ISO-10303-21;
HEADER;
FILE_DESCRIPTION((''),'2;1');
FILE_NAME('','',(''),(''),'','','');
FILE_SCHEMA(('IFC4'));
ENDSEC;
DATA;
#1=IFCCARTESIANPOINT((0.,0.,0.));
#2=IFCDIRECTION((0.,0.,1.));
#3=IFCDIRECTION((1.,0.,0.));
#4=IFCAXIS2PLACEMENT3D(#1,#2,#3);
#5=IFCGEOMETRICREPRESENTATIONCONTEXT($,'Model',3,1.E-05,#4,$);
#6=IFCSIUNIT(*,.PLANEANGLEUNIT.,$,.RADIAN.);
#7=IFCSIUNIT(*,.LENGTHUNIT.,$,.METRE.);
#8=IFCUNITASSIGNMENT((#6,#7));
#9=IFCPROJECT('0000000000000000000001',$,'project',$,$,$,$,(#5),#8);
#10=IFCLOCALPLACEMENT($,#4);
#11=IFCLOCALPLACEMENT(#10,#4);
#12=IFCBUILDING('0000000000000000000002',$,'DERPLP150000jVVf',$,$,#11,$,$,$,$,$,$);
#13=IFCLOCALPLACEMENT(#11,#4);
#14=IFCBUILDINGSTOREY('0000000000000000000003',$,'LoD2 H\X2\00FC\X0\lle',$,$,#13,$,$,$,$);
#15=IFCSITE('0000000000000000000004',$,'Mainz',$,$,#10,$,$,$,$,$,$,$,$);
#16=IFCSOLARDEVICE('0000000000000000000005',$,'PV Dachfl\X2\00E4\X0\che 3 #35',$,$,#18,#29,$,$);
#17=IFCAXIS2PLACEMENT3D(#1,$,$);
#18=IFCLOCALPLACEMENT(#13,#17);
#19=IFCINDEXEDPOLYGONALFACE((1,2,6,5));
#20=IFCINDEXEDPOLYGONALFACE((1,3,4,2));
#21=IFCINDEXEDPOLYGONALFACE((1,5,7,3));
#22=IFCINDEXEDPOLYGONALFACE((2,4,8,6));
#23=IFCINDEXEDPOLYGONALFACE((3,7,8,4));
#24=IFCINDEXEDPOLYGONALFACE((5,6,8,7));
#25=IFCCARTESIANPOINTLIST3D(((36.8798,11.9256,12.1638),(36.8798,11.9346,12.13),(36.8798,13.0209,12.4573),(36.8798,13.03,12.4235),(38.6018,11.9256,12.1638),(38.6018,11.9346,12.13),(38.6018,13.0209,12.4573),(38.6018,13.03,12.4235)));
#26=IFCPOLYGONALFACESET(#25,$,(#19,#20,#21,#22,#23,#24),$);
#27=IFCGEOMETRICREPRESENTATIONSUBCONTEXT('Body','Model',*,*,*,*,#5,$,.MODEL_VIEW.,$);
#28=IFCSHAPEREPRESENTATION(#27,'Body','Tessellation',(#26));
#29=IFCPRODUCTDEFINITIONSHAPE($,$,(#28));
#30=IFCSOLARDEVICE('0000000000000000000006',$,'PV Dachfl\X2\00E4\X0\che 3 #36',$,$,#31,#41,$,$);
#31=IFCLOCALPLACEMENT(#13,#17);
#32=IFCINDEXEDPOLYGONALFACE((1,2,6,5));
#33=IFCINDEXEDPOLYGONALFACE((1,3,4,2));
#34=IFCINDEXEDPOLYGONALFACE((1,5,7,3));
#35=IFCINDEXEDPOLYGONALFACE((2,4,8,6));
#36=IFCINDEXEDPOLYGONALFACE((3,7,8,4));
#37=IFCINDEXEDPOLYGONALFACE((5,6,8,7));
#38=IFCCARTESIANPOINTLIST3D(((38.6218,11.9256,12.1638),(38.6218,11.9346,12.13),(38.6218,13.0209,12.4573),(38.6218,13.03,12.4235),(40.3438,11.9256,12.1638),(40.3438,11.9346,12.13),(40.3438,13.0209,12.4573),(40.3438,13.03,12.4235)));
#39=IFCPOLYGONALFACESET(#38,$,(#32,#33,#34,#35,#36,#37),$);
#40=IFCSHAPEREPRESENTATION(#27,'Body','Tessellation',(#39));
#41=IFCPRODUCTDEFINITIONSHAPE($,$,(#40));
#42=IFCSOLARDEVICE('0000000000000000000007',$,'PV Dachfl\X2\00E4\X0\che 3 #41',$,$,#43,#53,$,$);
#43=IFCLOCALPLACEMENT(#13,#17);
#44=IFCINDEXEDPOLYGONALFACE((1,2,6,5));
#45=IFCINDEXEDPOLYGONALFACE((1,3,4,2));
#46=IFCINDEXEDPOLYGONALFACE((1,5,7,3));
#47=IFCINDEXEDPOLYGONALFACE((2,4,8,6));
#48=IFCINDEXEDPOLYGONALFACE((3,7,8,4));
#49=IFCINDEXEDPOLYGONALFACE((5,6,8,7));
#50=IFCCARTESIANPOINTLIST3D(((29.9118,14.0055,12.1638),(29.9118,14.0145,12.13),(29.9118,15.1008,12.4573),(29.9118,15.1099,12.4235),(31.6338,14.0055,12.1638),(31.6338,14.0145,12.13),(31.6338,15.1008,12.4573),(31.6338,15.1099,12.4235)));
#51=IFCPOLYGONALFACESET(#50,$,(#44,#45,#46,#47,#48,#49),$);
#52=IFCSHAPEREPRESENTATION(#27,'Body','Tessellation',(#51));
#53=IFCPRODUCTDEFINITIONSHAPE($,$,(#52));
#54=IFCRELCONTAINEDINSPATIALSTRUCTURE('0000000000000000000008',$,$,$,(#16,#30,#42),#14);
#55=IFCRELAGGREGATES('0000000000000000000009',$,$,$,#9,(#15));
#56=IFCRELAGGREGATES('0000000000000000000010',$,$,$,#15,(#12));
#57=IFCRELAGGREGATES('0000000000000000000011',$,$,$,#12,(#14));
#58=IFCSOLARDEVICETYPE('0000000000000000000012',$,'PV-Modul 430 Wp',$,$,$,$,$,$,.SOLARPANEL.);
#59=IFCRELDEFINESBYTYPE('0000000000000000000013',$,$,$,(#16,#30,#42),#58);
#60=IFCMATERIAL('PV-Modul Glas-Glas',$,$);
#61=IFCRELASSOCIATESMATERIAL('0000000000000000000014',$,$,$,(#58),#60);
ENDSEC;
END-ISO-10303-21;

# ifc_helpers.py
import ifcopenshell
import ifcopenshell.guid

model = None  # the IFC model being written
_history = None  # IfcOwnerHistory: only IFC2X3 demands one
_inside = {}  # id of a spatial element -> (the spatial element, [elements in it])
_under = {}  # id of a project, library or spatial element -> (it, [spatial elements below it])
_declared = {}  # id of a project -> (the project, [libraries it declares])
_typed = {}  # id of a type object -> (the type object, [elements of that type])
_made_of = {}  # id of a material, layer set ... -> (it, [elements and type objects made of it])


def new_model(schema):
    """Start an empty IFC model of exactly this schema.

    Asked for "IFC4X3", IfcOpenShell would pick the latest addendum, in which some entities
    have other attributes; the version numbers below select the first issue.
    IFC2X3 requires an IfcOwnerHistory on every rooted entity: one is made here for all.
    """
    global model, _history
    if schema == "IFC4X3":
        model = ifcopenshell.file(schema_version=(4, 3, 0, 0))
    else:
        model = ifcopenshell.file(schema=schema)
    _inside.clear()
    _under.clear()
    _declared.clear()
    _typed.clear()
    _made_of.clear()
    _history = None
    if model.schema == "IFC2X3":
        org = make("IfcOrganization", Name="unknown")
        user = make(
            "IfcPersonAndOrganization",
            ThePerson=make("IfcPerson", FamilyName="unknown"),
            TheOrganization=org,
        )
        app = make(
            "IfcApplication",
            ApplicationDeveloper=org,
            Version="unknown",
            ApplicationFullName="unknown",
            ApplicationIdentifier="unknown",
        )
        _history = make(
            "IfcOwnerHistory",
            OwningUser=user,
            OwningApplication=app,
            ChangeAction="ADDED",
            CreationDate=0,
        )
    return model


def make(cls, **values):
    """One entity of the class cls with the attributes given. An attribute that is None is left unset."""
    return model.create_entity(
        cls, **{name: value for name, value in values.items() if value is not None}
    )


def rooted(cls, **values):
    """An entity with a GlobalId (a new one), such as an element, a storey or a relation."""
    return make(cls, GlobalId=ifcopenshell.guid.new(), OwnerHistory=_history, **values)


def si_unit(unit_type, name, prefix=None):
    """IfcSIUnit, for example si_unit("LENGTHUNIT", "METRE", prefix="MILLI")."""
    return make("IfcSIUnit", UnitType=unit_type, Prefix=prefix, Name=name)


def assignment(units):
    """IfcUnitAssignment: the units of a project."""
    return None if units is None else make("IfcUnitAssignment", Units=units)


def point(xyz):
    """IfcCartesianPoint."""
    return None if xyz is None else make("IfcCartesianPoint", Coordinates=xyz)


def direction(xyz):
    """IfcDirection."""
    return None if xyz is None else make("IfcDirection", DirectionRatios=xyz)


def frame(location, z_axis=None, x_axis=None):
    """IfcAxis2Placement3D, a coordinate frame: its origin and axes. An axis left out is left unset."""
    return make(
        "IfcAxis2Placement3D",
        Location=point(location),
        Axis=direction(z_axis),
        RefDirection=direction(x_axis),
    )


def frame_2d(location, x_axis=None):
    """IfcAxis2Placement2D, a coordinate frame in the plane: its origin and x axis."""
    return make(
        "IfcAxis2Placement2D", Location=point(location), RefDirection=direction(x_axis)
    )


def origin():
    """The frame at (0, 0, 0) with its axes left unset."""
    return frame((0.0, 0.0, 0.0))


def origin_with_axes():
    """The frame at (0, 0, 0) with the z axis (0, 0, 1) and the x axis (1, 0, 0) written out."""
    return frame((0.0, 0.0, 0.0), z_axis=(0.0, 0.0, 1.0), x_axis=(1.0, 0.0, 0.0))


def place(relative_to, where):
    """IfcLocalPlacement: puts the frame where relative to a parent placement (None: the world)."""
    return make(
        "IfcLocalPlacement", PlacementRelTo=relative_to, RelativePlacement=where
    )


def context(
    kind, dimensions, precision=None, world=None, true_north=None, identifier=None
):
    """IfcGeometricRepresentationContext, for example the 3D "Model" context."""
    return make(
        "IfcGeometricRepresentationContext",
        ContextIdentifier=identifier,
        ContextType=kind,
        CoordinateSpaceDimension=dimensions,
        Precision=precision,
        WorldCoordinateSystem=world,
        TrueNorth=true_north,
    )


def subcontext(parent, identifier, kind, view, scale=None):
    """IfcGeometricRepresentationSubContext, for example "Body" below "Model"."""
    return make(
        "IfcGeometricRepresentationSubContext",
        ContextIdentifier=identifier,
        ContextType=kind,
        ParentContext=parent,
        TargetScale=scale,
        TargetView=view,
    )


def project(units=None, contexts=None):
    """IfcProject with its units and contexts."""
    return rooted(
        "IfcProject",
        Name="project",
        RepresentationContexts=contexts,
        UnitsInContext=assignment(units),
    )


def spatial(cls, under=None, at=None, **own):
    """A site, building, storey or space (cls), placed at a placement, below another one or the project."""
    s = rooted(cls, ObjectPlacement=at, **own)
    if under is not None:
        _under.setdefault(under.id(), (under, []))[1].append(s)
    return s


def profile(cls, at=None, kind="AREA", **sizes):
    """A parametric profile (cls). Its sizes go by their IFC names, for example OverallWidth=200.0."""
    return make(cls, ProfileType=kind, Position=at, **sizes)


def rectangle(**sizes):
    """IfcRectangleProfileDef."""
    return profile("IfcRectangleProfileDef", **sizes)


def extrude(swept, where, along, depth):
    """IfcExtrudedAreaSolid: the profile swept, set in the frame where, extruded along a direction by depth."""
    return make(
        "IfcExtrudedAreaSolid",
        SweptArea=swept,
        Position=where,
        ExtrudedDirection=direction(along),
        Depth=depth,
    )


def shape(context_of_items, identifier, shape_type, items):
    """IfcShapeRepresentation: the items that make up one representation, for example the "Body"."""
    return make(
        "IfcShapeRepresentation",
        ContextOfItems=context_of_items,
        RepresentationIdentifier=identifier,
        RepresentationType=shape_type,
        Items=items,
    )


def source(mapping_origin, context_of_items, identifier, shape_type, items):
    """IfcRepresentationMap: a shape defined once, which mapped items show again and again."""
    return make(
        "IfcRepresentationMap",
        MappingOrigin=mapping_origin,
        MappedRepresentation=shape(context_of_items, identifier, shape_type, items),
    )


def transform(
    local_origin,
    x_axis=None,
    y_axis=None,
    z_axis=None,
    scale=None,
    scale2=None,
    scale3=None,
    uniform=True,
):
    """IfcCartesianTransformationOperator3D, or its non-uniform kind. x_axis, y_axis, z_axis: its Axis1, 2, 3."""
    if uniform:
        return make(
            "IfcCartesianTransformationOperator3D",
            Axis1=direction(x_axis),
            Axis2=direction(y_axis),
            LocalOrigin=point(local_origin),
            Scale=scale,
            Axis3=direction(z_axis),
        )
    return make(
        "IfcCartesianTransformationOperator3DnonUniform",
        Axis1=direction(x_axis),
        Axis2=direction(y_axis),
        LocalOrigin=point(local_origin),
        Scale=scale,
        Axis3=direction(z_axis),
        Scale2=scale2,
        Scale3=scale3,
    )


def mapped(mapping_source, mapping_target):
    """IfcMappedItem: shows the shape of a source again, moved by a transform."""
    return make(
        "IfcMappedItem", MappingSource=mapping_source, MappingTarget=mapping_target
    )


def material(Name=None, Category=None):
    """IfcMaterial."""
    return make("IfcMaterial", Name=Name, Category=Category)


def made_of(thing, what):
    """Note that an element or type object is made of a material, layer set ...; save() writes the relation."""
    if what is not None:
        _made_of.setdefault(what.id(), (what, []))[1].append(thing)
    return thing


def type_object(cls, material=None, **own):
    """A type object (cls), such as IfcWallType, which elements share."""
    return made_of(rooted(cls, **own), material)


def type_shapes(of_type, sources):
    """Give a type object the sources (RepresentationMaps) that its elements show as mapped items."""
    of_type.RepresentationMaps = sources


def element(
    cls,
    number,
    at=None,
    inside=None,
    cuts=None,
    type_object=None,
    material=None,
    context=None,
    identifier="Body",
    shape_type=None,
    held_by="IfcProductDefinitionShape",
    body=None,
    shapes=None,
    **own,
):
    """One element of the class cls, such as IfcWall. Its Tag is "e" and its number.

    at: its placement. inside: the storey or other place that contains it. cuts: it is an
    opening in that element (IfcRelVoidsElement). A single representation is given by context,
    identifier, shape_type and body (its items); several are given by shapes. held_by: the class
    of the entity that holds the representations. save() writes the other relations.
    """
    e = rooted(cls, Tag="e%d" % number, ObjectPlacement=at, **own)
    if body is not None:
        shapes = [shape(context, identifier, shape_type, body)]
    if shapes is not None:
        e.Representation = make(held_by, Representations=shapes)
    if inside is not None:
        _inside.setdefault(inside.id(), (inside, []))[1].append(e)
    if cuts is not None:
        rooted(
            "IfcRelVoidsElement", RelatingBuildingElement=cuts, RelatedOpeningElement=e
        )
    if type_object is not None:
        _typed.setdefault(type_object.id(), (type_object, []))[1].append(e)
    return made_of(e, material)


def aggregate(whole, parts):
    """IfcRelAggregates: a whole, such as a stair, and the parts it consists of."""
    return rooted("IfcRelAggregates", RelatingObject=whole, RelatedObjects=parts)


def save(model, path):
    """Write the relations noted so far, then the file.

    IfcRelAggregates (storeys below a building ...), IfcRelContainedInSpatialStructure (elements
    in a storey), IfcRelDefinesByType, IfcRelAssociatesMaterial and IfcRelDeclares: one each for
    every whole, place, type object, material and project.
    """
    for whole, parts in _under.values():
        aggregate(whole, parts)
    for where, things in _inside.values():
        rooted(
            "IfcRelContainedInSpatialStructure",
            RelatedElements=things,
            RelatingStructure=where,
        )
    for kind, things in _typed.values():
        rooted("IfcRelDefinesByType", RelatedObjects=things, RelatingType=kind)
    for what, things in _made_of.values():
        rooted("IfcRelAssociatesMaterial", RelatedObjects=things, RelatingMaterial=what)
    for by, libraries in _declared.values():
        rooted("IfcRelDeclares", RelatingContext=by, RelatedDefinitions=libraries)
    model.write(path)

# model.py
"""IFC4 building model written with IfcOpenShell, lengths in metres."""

from ifc_helpers import new_model, si_unit, frame, frame_2d, origin, origin_with_axes, place, context, subcontext, project, spatial, rectangle, extrude, source, transform, mapped, material, type_object, type_shapes, element, save


model = new_model("IFC4")

# Units and contexts
model_context = context("Model", 3, precision=1e-05, world=origin_with_axes())
body_context = subcontext(model_context, "Body", "Model", "MODEL_VIEW")
ifc_project = project(units=[si_unit("PLANEANGLEUNIT", "RADIAN"), si_unit("LENGTHUNIT", "METRE")], contexts=[model_context])

# Site, building, storey
site_placement = place(None, origin_with_axes())
site = spatial("IfcSite", under=ifc_project, at=site_placement, Name="Mainz")
building_placement = place(site_placement, origin_with_axes())
building = spatial("IfcBuilding", under=site, at=building_placement, Name="DERPLP150000jVVf")
storey_placement = place(building_placement, origin_with_axes())
storey = spatial("IfcBuildingStorey", under=building, at=storey_placement, Name="LoD2 Hülle")

# Solar devices
ifc_material = material(Name="PV-Modul Glas-Glas")
solar_device_type = type_object("IfcSolarDeviceType", Name="PV-Modul 430 Wp", PredefinedType="SOLARPANEL", material=ifc_material)
shared_shape = source(origin_with_axes(), body_context, "Body", "SweptSolid", [
    extrude(rectangle(XDim=1.722, YDim=1.134, at=frame_2d((0.861, 0.567))), origin(), (0.0, 0.0, 1.0), 0.035),
])
type_shapes(solar_device_type, [shared_shape])
for number, where, z_axis, x_axis, name in (
    (1, (36.8798, 11.9346, 12.13), (0.0, -0.258819, 0.965926), (1.0, 0.0, 0.0), "PV Dachfläche 3 #35"),
    (2, (38.6218, 11.9346, 12.13), (0.0, -0.258819, 0.965926), (1.0, 0.0, 0.0), "PV Dachfläche 3 #36"),
    (3, (29.9118, 14.0145, 12.13), (0.0, -0.258819, 0.965926), (1.0, 0.0, 0.0), "PV Dachfläche 3 #41"),
):
    element("IfcSolarDevice", number, at=place(storey_placement, frame(where, z_axis=z_axis, x_axis=x_axis)), inside=storey, type_object=solar_device_type, Name=name, context=body_context, shape_type="MappedRepresentation", body=[
        mapped(shared_shape, transform((0.0, 0.0, 0.0), x_axis=(1.0, 0.0, 0.0), y_axis=(0.0, 1.0, 0.0), z_axis=(0.0, 0.0, 1.0), scale=1.0)),
    ])

save(model, "model.ifc")
